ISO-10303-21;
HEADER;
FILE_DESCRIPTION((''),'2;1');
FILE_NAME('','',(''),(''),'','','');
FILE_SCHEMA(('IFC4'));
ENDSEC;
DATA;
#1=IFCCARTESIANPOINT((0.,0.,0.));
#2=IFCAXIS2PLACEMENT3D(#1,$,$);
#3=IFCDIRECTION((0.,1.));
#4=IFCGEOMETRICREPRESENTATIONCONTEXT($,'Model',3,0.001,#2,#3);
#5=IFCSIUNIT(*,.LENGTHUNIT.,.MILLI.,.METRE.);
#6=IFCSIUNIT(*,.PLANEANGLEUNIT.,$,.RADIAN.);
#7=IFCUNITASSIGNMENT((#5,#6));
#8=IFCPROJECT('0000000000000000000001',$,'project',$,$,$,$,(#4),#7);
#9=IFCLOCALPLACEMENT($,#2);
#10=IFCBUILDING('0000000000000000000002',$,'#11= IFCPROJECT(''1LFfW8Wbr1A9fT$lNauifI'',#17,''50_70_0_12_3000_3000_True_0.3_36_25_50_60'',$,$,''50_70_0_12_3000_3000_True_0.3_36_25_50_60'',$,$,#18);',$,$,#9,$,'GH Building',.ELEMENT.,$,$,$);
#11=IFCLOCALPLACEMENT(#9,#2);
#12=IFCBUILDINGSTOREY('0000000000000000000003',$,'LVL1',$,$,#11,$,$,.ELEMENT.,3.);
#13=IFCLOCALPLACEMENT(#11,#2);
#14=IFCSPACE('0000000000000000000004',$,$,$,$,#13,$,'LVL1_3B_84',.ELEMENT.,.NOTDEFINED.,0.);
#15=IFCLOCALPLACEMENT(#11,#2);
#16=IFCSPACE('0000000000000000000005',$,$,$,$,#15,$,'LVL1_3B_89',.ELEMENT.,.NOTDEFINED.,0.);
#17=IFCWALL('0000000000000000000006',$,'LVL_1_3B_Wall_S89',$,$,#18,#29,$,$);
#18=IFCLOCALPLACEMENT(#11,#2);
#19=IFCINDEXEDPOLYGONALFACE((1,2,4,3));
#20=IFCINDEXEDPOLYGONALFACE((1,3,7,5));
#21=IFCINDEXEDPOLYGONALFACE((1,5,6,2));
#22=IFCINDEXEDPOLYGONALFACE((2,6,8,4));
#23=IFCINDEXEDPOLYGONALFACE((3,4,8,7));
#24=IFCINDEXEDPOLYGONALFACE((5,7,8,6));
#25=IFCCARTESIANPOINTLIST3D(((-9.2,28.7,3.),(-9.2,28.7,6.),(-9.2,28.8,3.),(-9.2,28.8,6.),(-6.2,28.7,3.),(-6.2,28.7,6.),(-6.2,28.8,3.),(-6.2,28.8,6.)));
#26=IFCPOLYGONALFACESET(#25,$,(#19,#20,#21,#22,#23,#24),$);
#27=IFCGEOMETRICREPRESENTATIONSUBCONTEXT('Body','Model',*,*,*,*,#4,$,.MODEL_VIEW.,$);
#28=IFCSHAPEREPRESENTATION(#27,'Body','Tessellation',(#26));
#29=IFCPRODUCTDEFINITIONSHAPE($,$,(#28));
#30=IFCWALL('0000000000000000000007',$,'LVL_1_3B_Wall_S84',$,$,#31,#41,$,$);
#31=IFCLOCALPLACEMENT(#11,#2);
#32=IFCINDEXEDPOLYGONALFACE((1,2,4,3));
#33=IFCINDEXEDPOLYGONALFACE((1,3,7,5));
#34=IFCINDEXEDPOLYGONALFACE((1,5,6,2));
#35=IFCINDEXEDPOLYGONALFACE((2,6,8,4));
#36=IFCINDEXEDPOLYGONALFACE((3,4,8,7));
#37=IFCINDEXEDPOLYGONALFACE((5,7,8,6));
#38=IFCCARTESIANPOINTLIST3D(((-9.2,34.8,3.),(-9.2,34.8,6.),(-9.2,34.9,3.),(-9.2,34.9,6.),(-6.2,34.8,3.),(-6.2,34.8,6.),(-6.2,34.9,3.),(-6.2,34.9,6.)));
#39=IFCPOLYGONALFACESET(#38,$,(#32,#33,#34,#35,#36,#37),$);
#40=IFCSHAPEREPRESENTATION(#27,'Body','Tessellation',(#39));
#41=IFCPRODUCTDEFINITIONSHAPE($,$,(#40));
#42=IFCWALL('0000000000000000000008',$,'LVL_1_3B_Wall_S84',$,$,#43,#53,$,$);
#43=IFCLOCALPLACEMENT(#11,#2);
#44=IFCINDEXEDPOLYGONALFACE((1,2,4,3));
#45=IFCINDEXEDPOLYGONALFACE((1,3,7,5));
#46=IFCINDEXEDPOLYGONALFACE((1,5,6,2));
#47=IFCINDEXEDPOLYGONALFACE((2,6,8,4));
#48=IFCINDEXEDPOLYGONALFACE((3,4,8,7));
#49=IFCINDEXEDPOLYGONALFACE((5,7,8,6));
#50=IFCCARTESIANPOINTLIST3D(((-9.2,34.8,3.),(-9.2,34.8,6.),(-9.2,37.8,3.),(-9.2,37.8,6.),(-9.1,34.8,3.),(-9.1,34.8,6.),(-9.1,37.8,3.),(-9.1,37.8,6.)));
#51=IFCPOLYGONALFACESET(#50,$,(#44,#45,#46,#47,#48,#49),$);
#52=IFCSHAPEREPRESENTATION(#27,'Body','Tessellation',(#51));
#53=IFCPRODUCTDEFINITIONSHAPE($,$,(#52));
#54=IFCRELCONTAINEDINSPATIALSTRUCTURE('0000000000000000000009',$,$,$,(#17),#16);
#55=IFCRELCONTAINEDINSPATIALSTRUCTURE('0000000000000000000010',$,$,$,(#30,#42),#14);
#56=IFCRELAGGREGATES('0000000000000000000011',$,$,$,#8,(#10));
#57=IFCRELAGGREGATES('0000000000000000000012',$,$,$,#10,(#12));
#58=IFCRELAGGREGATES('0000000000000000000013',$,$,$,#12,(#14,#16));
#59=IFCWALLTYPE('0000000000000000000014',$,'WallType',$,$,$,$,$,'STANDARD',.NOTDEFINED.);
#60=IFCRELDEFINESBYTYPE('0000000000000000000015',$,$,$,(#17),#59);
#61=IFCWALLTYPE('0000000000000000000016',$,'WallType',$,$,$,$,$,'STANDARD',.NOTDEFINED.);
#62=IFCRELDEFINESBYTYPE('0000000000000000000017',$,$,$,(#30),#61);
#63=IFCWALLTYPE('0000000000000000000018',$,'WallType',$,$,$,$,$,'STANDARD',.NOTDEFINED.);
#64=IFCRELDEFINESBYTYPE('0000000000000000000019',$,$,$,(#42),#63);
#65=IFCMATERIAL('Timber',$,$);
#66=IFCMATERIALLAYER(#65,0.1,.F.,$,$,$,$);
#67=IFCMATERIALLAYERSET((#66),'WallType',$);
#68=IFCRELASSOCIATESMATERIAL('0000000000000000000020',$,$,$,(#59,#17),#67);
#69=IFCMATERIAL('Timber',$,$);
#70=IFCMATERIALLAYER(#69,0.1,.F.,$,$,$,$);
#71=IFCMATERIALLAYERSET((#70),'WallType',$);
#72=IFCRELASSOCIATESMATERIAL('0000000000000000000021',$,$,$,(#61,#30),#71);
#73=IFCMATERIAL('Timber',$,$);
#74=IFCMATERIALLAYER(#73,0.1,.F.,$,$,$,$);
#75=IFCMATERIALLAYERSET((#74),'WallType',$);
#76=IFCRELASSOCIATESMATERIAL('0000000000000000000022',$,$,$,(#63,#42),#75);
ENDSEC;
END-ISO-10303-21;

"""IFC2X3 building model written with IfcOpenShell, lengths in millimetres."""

from ifc_helpers import new_model, si_unit, direction, frame, frame_2d, origin, place, context, subcontext, project, spatial, rectangle, extrude, material, layer, layer_set, layer_usage, type_object, element, save


model = new_model("IFC2X3")

# Units and contexts
model_context = context("Model", 3, precision=0.001, world=origin(), true_north=direction((0.0, 1.0)))
body_context = subcontext(model_context, "Body", "Model", "MODEL_VIEW")
ifc_project = project(units=[si_unit("LENGTHUNIT", "METRE", prefix="MILLI"), si_unit("PLANEANGLEUNIT", "RADIAN")], contexts=[model_context])

# Building, storey
building_placement = place(None, origin())
building = spatial("IfcBuilding", under=ifc_project, at=building_placement, Name="#11= IFCPROJECT('1LFfW8Wbr1A9fT$lNauifI',#17,'50_70_0_12_3000_3000_True_0.3_36_25_50_60',$,$,'50_70_0_12_3000_3000_True_0.3_36_25_50_60',$,$,#18);", LongName="GH Building", CompositionType="ELEMENT")
storey_placement = place(building_placement, origin())
storey = spatial("IfcBuildingStorey", under=building, at=storey_placement, Name="LVL1", CompositionType="ELEMENT", Elevation=3.0)

# Shared definitions
space_1_placement = place(storey_placement, origin())
space_1 = spatial("IfcSpace", under=storey, at=space_1_placement, LongName="LVL1_3B_84", CompositionType="ELEMENT", InteriorOrExteriorSpace="NOTDEFINED", ElevationWithFlooring=0.0)

# Shared definitions
space_2_placement = place(storey_placement, origin())
space_2 = spatial("IfcSpace", under=storey, at=space_2_placement, LongName="LVL1_3B_89", CompositionType="ELEMENT", InteriorOrExteriorSpace="NOTDEFINED", ElevationWithFlooring=0.0)

# Walls
ifc_material_1 = material(Name="Timber")
ifc_layer_1 = layer(ifc_material_1, 0.1, ventilated=False)
ifc_layer_set_1 = layer_set([ifc_layer_1], Name="WallType")
ifc_layer_usage_1 = layer_usage(ifc_layer_set_1, "AXIS2", "NEGATIVE", 0.0)
wall_type_1 = type_object("IfcWallType", Name="WallType", ElementType="STANDARD", PredefinedType="NOTDEFINED", material=ifc_layer_set_1)
wall_1_placement = place(space_2_placement, frame((-9.2, 28.8, 3.0)))
element("IfcWall", 1, at=wall_1_placement, inside=space_2, type_object=wall_type_1, material=ifc_layer_usage_1, Name="LVL_1_3B_Wall_S89", context=body_context, shape_type="SweptSolid", body=[
    extrude(rectangle(XDim=3.0, YDim=0.1, at=frame_2d((1.5, -0.1))), origin(), (0.0, 0.0, 1.0), 3.0),
])
ifc_material_2 = material(Name="Timber")
ifc_layer_2 = layer(ifc_material_2, 0.1, ventilated=False)
ifc_layer_set_2 = layer_set([ifc_layer_2], Name="WallType")
ifc_layer_usage_2 = layer_usage(ifc_layer_set_2, "AXIS2", "NEGATIVE", 0.0)
wall_type_2 = type_object("IfcWallType", Name="WallType", ElementType="STANDARD", PredefinedType="NOTDEFINED", material=ifc_layer_set_2)
wall_2_placement = place(space_1_placement, frame((-6.2, 34.8, 3.0), z_axis=(0.0, 0.0, 1.0), x_axis=(-1.0, 0.0, 0.0)))
element("IfcWall", 2, at=wall_2_placement, inside=space_1, type_object=wall_type_2, material=ifc_layer_usage_2, Name="LVL_1_3B_Wall_S84", context=body_context, shape_type="SweptSolid", body=[
    extrude(rectangle(XDim=3.0, YDim=0.1, at=frame_2d((1.5, -0.1))), origin(), (0.0, 0.0, 1.0), 3.0),
])
ifc_material_3 = material(Name="Timber")
ifc_layer_3 = layer(ifc_material_3, 0.1, ventilated=False)
ifc_layer_set_3 = layer_set([ifc_layer_3], Name="WallType")
ifc_layer_usage_3 = layer_usage(ifc_layer_set_3, "AXIS2", "NEGATIVE", 0.0)
wall_type_3 = type_object("IfcWallType", Name="WallType", ElementType="STANDARD", PredefinedType="NOTDEFINED", material=ifc_layer_set_3)
wall_3_placement = place(space_1_placement, frame((-9.2, 34.8, 3.0), z_axis=(0.0, 0.0, 1.0), x_axis=(0.0, 1.0, 0.0)))
element("IfcWall", 3, at=wall_3_placement, inside=space_1, type_object=wall_type_3, material=ifc_layer_usage_3, Name="LVL_1_3B_Wall_S84", context=body_context, shape_type="SweptSolid", body=[
    extrude(rectangle(XDim=3.0, YDim=0.1, at=frame_2d((1.5, -0.1))), origin(), (0.0, 0.0, 1.0), 3.0),
])

save(model, "model.ifc")
